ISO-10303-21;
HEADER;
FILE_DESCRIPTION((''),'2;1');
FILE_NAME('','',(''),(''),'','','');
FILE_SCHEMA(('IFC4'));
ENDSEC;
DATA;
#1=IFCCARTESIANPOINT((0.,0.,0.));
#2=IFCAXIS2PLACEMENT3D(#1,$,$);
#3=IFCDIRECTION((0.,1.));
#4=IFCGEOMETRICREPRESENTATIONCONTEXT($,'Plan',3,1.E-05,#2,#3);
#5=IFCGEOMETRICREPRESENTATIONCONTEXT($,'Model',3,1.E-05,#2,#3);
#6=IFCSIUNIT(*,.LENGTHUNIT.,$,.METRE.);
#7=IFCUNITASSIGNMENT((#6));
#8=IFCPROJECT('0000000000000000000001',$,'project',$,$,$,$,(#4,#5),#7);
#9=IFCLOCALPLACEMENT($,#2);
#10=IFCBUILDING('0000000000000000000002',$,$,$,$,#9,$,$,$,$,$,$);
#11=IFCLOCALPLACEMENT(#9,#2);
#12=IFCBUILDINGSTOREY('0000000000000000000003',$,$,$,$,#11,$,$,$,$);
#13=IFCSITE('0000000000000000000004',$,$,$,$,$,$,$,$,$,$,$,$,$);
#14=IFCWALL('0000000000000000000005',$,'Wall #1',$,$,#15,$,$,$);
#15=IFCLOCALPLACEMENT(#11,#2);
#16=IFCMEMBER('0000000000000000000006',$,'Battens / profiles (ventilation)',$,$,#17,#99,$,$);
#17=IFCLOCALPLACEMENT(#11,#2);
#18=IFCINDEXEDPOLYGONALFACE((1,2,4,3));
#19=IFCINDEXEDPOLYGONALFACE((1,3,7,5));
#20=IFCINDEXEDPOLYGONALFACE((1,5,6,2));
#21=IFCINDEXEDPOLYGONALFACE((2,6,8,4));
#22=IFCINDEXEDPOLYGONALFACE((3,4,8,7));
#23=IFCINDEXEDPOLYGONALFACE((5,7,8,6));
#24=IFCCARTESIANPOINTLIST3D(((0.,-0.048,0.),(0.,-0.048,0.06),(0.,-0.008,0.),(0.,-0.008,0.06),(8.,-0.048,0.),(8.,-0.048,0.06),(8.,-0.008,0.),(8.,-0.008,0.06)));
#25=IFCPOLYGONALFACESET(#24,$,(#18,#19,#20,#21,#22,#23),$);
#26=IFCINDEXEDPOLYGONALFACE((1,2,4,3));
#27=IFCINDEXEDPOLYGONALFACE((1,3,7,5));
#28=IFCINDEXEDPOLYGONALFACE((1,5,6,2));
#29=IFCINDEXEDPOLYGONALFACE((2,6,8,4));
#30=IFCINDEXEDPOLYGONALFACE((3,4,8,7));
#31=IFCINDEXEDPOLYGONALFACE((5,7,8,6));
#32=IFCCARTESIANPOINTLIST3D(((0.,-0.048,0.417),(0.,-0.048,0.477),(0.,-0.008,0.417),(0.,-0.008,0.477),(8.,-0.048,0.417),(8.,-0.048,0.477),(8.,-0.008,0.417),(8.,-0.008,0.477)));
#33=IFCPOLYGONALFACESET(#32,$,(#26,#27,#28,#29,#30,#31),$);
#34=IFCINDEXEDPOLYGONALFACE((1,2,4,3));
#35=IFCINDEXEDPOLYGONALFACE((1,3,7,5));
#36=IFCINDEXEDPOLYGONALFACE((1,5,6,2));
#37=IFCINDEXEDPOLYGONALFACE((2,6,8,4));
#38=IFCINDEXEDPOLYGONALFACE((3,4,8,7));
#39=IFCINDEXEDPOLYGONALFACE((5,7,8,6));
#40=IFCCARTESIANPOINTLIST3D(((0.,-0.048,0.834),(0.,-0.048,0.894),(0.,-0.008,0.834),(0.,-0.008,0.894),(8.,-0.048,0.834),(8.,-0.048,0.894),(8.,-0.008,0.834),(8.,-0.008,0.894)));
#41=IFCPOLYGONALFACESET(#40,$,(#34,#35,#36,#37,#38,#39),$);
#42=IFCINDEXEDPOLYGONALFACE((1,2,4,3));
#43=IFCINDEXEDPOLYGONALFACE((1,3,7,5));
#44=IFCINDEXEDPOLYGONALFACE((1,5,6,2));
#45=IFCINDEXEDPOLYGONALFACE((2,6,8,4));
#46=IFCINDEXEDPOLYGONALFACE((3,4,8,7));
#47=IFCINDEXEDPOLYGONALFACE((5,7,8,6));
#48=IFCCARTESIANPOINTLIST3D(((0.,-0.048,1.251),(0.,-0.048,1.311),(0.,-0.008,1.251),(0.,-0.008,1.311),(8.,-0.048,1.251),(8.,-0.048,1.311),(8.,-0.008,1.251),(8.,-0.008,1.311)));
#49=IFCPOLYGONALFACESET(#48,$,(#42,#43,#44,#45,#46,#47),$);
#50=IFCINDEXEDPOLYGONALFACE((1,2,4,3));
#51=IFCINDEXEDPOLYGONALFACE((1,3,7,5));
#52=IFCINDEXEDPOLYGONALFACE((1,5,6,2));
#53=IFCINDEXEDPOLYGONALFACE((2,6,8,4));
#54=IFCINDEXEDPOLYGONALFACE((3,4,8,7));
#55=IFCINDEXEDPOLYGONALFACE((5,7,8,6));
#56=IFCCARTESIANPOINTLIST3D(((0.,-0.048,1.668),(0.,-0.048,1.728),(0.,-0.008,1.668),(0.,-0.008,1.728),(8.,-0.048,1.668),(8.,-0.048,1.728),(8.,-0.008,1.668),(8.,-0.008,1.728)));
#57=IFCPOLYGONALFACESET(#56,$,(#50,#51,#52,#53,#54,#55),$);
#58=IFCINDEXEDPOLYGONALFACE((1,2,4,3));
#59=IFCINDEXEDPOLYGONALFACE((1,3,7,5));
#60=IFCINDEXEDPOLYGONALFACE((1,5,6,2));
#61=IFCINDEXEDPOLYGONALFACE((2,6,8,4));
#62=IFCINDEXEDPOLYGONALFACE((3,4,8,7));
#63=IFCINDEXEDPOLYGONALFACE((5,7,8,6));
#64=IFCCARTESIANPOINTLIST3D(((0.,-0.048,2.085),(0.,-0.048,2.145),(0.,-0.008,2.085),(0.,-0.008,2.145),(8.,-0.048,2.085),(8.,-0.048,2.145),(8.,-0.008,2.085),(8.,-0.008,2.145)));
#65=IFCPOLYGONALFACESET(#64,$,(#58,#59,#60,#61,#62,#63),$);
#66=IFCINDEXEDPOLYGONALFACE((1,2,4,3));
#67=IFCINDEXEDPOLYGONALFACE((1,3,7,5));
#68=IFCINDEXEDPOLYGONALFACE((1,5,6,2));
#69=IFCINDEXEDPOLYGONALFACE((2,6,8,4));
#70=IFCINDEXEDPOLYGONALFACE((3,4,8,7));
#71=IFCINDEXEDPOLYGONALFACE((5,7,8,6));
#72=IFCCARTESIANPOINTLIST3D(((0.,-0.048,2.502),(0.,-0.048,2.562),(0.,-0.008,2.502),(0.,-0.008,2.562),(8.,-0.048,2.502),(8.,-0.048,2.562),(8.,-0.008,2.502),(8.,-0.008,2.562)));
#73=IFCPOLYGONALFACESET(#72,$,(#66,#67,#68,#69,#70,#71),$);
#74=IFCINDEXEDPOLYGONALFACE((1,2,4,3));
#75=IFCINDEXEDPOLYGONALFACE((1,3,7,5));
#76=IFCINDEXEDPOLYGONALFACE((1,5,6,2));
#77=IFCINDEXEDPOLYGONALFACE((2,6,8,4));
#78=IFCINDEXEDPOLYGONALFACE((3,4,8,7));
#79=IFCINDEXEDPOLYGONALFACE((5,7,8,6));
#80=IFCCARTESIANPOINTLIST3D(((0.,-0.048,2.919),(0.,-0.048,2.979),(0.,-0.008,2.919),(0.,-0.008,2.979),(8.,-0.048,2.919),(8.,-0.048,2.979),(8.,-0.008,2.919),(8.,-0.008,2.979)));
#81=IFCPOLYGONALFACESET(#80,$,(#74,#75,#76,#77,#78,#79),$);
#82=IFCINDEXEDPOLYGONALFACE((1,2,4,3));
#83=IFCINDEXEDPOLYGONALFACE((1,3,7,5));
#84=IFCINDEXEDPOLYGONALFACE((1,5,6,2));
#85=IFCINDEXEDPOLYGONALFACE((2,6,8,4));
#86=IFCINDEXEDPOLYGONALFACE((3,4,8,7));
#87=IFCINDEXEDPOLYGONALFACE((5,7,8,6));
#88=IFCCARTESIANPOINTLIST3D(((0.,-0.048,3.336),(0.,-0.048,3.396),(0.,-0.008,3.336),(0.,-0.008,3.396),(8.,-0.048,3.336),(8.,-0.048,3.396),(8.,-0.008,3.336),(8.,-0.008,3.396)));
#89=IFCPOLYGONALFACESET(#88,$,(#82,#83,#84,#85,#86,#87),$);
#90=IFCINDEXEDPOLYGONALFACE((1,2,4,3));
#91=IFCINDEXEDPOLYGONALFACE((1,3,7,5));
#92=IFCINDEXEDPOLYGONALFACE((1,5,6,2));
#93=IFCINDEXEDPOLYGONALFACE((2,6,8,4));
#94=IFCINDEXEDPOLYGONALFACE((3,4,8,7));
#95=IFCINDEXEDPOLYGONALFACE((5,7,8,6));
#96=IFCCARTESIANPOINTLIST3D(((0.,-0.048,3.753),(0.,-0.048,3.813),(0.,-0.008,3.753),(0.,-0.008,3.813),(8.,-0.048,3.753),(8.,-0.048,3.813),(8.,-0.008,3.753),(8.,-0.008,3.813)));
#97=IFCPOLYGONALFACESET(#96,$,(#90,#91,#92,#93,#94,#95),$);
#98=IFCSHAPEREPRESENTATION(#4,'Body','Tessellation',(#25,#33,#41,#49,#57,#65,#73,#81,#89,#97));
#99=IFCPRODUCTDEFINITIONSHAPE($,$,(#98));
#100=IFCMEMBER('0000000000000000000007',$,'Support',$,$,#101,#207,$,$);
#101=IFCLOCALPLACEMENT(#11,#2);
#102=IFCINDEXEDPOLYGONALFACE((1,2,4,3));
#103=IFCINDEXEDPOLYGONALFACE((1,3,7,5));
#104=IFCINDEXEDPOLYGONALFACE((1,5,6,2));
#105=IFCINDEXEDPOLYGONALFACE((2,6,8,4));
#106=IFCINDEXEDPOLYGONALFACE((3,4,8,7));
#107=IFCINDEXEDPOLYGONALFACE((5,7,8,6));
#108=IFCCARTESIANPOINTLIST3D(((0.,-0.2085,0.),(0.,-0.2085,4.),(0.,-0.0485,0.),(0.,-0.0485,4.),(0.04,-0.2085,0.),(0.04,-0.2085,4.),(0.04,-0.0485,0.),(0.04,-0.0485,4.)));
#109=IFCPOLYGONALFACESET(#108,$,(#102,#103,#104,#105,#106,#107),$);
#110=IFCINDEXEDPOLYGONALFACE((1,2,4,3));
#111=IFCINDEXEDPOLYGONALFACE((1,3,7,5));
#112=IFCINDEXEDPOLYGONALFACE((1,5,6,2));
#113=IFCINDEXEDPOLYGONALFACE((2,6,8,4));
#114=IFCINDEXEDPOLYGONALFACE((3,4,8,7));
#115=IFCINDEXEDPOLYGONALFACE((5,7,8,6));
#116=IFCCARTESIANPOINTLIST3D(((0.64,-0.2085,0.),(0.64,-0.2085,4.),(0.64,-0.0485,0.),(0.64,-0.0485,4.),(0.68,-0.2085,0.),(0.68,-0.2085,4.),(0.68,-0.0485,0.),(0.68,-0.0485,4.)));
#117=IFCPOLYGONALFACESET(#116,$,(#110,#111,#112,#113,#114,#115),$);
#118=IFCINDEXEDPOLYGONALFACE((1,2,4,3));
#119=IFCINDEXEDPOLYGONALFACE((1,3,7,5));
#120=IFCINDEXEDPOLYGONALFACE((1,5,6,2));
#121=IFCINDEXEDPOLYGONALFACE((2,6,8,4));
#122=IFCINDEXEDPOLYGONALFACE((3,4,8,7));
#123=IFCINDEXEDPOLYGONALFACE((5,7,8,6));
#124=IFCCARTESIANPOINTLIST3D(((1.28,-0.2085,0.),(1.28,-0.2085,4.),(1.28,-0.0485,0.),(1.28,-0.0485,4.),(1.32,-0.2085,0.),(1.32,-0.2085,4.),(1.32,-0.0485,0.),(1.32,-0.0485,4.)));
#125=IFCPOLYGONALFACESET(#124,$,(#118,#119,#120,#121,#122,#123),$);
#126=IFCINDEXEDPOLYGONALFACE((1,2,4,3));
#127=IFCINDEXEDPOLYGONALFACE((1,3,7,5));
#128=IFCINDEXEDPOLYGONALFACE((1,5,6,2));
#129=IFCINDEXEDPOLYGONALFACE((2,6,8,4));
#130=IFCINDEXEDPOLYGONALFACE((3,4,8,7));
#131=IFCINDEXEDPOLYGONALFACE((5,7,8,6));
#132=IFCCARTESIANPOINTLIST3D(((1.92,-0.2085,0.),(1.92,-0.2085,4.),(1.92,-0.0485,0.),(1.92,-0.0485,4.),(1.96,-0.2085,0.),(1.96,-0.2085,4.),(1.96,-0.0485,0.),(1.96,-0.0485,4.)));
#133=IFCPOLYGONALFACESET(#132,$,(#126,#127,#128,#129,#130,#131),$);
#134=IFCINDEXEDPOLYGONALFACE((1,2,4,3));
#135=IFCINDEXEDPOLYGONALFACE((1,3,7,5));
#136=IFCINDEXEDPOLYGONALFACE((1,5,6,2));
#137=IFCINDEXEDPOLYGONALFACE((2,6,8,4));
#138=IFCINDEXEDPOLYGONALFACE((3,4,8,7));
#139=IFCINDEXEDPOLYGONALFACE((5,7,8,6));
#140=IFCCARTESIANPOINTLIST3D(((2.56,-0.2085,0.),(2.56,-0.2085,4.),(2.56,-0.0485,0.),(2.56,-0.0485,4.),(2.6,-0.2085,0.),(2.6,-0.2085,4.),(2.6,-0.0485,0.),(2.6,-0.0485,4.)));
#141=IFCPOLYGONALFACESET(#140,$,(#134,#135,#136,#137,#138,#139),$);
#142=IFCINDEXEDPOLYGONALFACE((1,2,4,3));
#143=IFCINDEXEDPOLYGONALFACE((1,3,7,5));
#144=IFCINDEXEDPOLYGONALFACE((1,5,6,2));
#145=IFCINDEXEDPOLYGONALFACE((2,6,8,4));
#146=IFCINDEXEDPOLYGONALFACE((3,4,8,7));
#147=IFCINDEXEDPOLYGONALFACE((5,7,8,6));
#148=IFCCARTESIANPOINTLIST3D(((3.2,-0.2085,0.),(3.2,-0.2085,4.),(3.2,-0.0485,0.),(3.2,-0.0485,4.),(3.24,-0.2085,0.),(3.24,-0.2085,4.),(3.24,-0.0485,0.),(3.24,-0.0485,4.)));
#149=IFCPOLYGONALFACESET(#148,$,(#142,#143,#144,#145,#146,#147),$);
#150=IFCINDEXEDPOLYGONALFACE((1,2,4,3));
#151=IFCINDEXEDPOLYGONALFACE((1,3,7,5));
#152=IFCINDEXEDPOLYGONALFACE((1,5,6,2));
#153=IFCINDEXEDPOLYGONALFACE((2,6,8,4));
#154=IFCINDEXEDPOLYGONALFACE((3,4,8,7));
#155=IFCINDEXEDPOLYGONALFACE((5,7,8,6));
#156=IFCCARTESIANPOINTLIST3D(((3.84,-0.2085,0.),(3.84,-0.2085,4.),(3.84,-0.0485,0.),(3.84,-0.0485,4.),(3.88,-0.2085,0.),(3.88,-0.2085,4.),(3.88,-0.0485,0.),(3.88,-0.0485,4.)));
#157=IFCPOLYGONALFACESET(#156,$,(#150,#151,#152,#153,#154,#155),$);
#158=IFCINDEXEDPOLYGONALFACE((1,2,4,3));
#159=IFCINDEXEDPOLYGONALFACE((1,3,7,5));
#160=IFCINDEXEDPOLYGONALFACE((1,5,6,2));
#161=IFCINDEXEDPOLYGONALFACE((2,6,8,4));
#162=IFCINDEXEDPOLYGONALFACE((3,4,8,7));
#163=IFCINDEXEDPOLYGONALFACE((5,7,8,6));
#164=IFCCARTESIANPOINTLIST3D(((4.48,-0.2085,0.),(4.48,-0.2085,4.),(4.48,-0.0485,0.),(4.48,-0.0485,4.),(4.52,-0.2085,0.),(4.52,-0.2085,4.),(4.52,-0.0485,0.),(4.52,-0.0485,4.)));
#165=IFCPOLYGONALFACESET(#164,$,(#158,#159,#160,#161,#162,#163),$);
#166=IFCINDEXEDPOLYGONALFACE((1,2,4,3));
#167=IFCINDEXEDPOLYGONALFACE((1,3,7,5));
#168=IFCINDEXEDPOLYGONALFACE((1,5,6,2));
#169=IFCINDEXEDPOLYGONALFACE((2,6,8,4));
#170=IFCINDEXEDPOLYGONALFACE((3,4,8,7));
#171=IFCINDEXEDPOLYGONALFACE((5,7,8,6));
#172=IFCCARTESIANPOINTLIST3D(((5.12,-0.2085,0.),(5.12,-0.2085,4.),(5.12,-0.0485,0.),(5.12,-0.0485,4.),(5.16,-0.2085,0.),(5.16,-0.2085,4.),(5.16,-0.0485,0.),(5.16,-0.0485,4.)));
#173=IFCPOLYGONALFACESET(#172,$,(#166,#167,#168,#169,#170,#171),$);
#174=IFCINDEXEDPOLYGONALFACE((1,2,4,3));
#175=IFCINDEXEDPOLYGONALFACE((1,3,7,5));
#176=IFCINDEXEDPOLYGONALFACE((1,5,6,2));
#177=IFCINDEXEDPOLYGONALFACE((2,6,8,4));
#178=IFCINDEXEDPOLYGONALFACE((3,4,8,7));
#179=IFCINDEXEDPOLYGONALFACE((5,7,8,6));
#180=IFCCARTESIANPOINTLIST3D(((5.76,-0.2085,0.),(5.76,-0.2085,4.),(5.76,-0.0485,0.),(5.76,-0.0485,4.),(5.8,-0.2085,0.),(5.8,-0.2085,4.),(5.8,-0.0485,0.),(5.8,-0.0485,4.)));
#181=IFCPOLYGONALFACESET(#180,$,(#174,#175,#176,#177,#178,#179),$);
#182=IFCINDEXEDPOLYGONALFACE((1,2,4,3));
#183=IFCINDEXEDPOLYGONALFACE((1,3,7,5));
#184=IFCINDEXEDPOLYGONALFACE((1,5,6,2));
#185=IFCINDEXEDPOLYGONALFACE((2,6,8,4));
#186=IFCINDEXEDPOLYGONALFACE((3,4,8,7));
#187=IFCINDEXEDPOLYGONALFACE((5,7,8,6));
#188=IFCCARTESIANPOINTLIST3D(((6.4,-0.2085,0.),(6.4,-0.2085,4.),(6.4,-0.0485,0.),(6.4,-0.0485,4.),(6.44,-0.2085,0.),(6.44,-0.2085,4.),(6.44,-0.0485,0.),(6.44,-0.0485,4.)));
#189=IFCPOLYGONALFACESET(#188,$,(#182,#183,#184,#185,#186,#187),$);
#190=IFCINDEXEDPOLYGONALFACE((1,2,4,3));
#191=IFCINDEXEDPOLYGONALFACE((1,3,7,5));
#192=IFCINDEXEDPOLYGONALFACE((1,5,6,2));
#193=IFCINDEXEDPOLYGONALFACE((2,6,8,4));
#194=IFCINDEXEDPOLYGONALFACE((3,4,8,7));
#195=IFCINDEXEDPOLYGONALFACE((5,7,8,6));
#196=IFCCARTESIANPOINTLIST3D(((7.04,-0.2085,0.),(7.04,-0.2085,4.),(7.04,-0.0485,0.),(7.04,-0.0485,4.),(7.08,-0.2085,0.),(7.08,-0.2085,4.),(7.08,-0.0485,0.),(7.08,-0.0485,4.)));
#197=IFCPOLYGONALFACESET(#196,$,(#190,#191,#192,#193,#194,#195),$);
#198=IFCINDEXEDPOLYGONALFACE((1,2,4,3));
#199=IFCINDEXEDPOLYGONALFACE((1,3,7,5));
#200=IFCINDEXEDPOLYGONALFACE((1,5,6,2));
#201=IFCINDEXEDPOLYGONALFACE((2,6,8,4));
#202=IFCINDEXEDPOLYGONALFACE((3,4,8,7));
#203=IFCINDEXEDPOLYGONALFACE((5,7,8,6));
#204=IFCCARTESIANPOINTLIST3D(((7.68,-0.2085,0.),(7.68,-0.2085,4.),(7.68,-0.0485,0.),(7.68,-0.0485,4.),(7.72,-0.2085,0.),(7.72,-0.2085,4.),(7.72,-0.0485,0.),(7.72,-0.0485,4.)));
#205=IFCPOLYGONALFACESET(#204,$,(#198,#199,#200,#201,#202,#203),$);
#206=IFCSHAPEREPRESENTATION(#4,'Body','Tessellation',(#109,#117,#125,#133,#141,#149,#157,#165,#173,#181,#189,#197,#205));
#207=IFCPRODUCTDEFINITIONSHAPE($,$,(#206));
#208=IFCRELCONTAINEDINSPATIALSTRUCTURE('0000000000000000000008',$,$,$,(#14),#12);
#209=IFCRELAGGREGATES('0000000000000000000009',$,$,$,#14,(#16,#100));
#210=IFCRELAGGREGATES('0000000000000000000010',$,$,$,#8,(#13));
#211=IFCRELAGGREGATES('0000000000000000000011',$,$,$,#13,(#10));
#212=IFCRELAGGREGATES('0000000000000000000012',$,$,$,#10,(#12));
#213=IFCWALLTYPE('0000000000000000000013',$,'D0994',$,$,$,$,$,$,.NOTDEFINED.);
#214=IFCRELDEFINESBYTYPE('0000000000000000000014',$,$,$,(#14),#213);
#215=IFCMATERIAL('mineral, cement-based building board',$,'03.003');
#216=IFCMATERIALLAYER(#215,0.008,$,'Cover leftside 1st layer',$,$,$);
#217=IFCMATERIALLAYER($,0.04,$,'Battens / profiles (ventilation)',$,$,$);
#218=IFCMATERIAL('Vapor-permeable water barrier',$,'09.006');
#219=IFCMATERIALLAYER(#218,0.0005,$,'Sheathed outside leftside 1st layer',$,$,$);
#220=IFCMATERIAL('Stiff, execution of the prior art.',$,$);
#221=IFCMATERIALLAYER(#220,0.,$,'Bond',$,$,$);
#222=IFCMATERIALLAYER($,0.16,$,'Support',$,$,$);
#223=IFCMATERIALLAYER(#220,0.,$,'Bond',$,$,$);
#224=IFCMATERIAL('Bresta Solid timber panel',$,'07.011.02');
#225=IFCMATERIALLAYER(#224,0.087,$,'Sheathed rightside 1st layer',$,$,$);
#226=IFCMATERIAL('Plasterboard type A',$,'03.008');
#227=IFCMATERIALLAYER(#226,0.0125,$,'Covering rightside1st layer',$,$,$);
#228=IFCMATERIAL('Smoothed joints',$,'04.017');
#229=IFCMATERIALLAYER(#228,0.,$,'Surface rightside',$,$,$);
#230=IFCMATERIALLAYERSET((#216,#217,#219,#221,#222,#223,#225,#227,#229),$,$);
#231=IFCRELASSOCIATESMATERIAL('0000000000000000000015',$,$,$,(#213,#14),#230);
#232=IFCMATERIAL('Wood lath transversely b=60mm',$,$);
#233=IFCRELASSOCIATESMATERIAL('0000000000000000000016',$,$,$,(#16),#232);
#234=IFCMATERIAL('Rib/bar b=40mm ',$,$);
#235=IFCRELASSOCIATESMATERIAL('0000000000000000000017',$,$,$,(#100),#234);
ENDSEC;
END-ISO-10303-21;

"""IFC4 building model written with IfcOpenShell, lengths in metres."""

from ifc_helpers import new_model, si_unit, direction, frame, frame_2d, origin, place, context, project, spatial, rectangle, extrude, material, layer, layer_set, type_object, element, aggregate, save


model = new_model("IFC4")

# Units and contexts
plan_context = context("Plan", 3, precision=1e-05, world=origin(), true_north=direction((0.0, 1.0)))
model_context = context("Model", 3, precision=1e-05, world=origin(), true_north=direction((0.0, 1.0)))
ifc_project = project(units=[si_unit("LENGTHUNIT", "METRE")], contexts=[plan_context, model_context])

# Site, building, storey
site = spatial("IfcSite", under=ifc_project)
building_placement = place(None, origin())
building = spatial("IfcBuilding", under=site, at=building_placement)
storey_placement = place(building_placement, origin())
storey = spatial("IfcBuildingStorey", under=building, at=storey_placement)

# Wall, members
ifc_material_1 = material(Name="mineral, cement-based building board", Category="03.003")
ifc_layer_1 = layer(ifc_material_1, 0.008, Name="Cover leftside 1st layer")
ifc_layer_2 = layer(None, 0.04, Name="Battens / profiles (ventilation)")
ifc_material_2 = material(Name="Vapor-permeable water barrier", Category="09.006")
ifc_layer_3 = layer(ifc_material_2, 0.0005, Name="Sheathed outside leftside 1st layer")
ifc_material_3 = material(Name="Stiff, execution of the prior art.")
ifc_layer_4 = layer(ifc_material_3, 0.0, Name="Bond")
ifc_layer_5 = layer(None, 0.16, Name="Support")
ifc_layer_6 = layer(ifc_material_3, 0.0, Name="Bond")
ifc_material_4 = material(Name="Bresta Solid timber panel", Category="07.011.02")
ifc_layer_7 = layer(ifc_material_4, 0.087, Name="Sheathed rightside 1st layer")
ifc_material_5 = material(Name="Plasterboard type A", Category="03.008")
ifc_layer_8 = layer(ifc_material_5, 0.0125, Name="Covering rightside1st layer")
ifc_material_6 = material(Name="Smoothed joints", Category="04.017")
ifc_layer_9 = layer(ifc_material_6, 0.0, Name="Surface rightside")
ifc_layer_set = layer_set([ifc_layer_1, ifc_layer_2, ifc_layer_3, ifc_layer_4, ifc_layer_5, ifc_layer_6, ifc_layer_7, ifc_layer_8, ifc_layer_9])
wall_type = type_object("IfcWallType", Name="D0994", PredefinedType="NOTDEFINED", material=ifc_layer_set)
wall_placement = place(None, frame((0.0, 0.0, 0.0), z_axis=(0.0, -1.0, 0.0), x_axis=(1.0, 0.0, 0.0)))
wall = element("IfcWall", 1, at=wall_placement, inside=storey, type_object=wall_type, material=ifc_layer_set, Name="Wall #1")
ifc_material_7 = material(Name="Wood lath transversely b=60mm")
member_1_placement = place(wall_placement, origin())
member_1 = element("IfcMember", 2, at=member_1_placement, material=ifc_material_7, Name="Battens / profiles (ventilation)", context=plan_context, shape_type="SweptSolid", body=[
    extrude(rectangle(XDim=0.06, YDim=0.04, at=frame_2d((0.03, 0.02), x_axis=(1.0, 0.0))), frame((0.0, 0.0, 0.008), z_axis=(1.0, 0.0, 0.0), x_axis=(0.0, 1.0, 0.0)), (0.0, 0.0, 1.0), 8.0),
    extrude(rectangle(XDim=0.06, YDim=0.04, at=frame_2d((0.03, 0.02), x_axis=(1.0, 0.0))), frame((0.0, 0.417, 0.008), z_axis=(1.0, 0.0, 0.0), x_axis=(0.0, 1.0, 0.0)), (0.0, 0.0, 1.0), 8.0),
    extrude(rectangle(XDim=0.06, YDim=0.04, at=frame_2d((0.03, 0.02), x_axis=(1.0, 0.0))), frame((0.0, 0.834, 0.008), z_axis=(1.0, 0.0, 0.0), x_axis=(0.0, 1.0, 0.0)), (0.0, 0.0, 1.0), 8.0),
    extrude(rectangle(XDim=0.06, YDim=0.04, at=frame_2d((0.03, 0.02), x_axis=(1.0, 0.0))), frame((0.0, 1.251, 0.008), z_axis=(1.0, 0.0, 0.0), x_axis=(0.0, 1.0, 0.0)), (0.0, 0.0, 1.0), 8.0),
    extrude(rectangle(XDim=0.06, YDim=0.04, at=frame_2d((0.03, 0.02), x_axis=(1.0, 0.0))), frame((0.0, 1.668, 0.008), z_axis=(1.0, 0.0, 0.0), x_axis=(0.0, 1.0, 0.0)), (0.0, 0.0, 1.0), 8.0),
    extrude(rectangle(XDim=0.06, YDim=0.04, at=frame_2d((0.03, 0.02), x_axis=(1.0, 0.0))), frame((0.0, 2.085, 0.008), z_axis=(1.0, 0.0, 0.0), x_axis=(0.0, 1.0, 0.0)), (0.0, 0.0, 1.0), 8.0),
    extrude(rectangle(XDim=0.06, YDim=0.04, at=frame_2d((0.03, 0.02), x_axis=(1.0, 0.0))), frame((0.0, 2.502, 0.008), z_axis=(1.0, 0.0, 0.0), x_axis=(0.0, 1.0, 0.0)), (0.0, 0.0, 1.0), 8.0),
    extrude(rectangle(XDim=0.06, YDim=0.04, at=frame_2d((0.03, 0.02), x_axis=(1.0, 0.0))), frame((0.0, 2.919, 0.008), z_axis=(1.0, 0.0, 0.0), x_axis=(0.0, 1.0, 0.0)), (0.0, 0.0, 1.0), 8.0),
    extrude(rectangle(XDim=0.06, YDim=0.04, at=frame_2d((0.03, 0.02), x_axis=(1.0, 0.0))), frame((0.0, 3.336, 0.008), z_axis=(1.0, 0.0, 0.0), x_axis=(0.0, 1.0, 0.0)), (0.0, 0.0, 1.0), 8.0),
    extrude(rectangle(XDim=0.06, YDim=0.04, at=frame_2d((0.03, 0.02), x_axis=(1.0, 0.0))), frame((0.0, 3.753, 0.008), z_axis=(1.0, 0.0, 0.0), x_axis=(0.0, 1.0, 0.0)), (0.0, 0.0, 1.0), 8.0),
])
ifc_material_8 = material(Name="Rib/bar b=40mm ")
member_2_placement = place(wall_placement, origin())
member_2 = element("IfcMember", 3, at=member_2_placement, material=ifc_material_8, Name="Support", context=plan_context, shape_type="SweptSolid", body=[
    extrude(rectangle(XDim=0.04, YDim=0.16, at=frame_2d((0.02, 0.08), x_axis=(1.0, 0.0))), frame((0.0, 4.0, 0.0485), z_axis=(0.0, -1.0, 0.0), x_axis=(1.0, 0.0, 0.0)), (0.0, 0.0, 1.0), 4.0),
    extrude(rectangle(XDim=0.04, YDim=0.16, at=frame_2d((0.02, 0.08), x_axis=(1.0, 0.0))), frame((0.64, 4.0, 0.0485), z_axis=(0.0, -1.0, 0.0), x_axis=(1.0, 0.0, 0.0)), (0.0, 0.0, 1.0), 4.0),
    extrude(rectangle(XDim=0.04, YDim=0.16, at=frame_2d((0.02, 0.08), x_axis=(1.0, 0.0))), frame((1.28, 4.0, 0.0485), z_axis=(0.0, -1.0, 0.0), x_axis=(1.0, 0.0, 0.0)), (0.0, 0.0, 1.0), 4.0),
    extrude(rectangle(XDim=0.04, YDim=0.16, at=frame_2d((0.02, 0.08), x_axis=(1.0, 0.0))), frame((1.92, 4.0, 0.0485), z_axis=(0.0, -1.0, 0.0), x_axis=(1.0, 0.0, 0.0)), (0.0, 0.0, 1.0), 4.0),
    extrude(rectangle(XDim=0.04, YDim=0.16, at=frame_2d((0.02, 0.08), x_axis=(1.0, 0.0))), frame((2.56, 4.0, 0.0485), z_axis=(0.0, -1.0, 0.0), x_axis=(1.0, 0.0, 0.0)), (0.0, 0.0, 1.0), 4.0),
    extrude(rectangle(XDim=0.04, YDim=0.16, at=frame_2d((0.02, 0.08), x_axis=(1.0, 0.0))), frame((3.2, 4.0, 0.0485), z_axis=(0.0, -1.0, 0.0), x_axis=(1.0, 0.0, 0.0)), (0.0, 0.0, 1.0), 4.0),
    extrude(rectangle(XDim=0.04, YDim=0.16, at=frame_2d((0.02, 0.08), x_axis=(1.0, 0.0))), frame((3.84, 4.0, 0.0485), z_axis=(0.0, -1.0, 0.0), x_axis=(1.0, 0.0, 0.0)), (0.0, 0.0, 1.0), 4.0),
    extrude(rectangle(XDim=0.04, YDim=0.16, at=frame_2d((0.02, 0.08), x_axis=(1.0, 0.0))), frame((4.48, 4.0, 0.0485), z_axis=(0.0, -1.0, 0.0), x_axis=(1.0, 0.0, 0.0)), (0.0, 0.0, 1.0), 4.0),
    extrude(rectangle(XDim=0.04, YDim=0.16, at=frame_2d((0.02, 0.08), x_axis=(1.0, 0.0))), frame((5.12, 4.0, 0.0485), z_axis=(0.0, -1.0, 0.0), x_axis=(1.0, 0.0, 0.0)), (0.0, 0.0, 1.0), 4.0),
    extrude(rectangle(XDim=0.04, YDim=0.16, at=frame_2d((0.02, 0.08), x_axis=(1.0, 0.0))), frame((5.76, 4.0, 0.0485), z_axis=(0.0, -1.0, 0.0), x_axis=(1.0, 0.0, 0.0)), (0.0, 0.0, 1.0), 4.0),
    extrude(rectangle(XDim=0.04, YDim=0.16, at=frame_2d((0.02, 0.08), x_axis=(1.0, 0.0))), frame((6.4, 4.0, 0.0485), z_axis=(0.0, -1.0, 0.0), x_axis=(1.0, 0.0, 0.0)), (0.0, 0.0, 1.0), 4.0),
    extrude(rectangle(XDim=0.04, YDim=0.16, at=frame_2d((0.02, 0.08), x_axis=(1.0, 0.0))), frame((7.04, 4.0, 0.0485), z_axis=(0.0, -1.0, 0.0), x_axis=(1.0, 0.0, 0.0)), (0.0, 0.0, 1.0), 4.0),
    extrude(rectangle(XDim=0.04, YDim=0.16, at=frame_2d((0.02, 0.08), x_axis=(1.0, 0.0))), frame((7.68, 4.0, 0.0485), z_axis=(0.0, -1.0, 0.0), x_axis=(1.0, 0.0, 0.0)), (0.0, 0.0, 1.0), 4.0),
])
aggregate(wall, [member_1, member_2])

save(model, "model.ifc")
